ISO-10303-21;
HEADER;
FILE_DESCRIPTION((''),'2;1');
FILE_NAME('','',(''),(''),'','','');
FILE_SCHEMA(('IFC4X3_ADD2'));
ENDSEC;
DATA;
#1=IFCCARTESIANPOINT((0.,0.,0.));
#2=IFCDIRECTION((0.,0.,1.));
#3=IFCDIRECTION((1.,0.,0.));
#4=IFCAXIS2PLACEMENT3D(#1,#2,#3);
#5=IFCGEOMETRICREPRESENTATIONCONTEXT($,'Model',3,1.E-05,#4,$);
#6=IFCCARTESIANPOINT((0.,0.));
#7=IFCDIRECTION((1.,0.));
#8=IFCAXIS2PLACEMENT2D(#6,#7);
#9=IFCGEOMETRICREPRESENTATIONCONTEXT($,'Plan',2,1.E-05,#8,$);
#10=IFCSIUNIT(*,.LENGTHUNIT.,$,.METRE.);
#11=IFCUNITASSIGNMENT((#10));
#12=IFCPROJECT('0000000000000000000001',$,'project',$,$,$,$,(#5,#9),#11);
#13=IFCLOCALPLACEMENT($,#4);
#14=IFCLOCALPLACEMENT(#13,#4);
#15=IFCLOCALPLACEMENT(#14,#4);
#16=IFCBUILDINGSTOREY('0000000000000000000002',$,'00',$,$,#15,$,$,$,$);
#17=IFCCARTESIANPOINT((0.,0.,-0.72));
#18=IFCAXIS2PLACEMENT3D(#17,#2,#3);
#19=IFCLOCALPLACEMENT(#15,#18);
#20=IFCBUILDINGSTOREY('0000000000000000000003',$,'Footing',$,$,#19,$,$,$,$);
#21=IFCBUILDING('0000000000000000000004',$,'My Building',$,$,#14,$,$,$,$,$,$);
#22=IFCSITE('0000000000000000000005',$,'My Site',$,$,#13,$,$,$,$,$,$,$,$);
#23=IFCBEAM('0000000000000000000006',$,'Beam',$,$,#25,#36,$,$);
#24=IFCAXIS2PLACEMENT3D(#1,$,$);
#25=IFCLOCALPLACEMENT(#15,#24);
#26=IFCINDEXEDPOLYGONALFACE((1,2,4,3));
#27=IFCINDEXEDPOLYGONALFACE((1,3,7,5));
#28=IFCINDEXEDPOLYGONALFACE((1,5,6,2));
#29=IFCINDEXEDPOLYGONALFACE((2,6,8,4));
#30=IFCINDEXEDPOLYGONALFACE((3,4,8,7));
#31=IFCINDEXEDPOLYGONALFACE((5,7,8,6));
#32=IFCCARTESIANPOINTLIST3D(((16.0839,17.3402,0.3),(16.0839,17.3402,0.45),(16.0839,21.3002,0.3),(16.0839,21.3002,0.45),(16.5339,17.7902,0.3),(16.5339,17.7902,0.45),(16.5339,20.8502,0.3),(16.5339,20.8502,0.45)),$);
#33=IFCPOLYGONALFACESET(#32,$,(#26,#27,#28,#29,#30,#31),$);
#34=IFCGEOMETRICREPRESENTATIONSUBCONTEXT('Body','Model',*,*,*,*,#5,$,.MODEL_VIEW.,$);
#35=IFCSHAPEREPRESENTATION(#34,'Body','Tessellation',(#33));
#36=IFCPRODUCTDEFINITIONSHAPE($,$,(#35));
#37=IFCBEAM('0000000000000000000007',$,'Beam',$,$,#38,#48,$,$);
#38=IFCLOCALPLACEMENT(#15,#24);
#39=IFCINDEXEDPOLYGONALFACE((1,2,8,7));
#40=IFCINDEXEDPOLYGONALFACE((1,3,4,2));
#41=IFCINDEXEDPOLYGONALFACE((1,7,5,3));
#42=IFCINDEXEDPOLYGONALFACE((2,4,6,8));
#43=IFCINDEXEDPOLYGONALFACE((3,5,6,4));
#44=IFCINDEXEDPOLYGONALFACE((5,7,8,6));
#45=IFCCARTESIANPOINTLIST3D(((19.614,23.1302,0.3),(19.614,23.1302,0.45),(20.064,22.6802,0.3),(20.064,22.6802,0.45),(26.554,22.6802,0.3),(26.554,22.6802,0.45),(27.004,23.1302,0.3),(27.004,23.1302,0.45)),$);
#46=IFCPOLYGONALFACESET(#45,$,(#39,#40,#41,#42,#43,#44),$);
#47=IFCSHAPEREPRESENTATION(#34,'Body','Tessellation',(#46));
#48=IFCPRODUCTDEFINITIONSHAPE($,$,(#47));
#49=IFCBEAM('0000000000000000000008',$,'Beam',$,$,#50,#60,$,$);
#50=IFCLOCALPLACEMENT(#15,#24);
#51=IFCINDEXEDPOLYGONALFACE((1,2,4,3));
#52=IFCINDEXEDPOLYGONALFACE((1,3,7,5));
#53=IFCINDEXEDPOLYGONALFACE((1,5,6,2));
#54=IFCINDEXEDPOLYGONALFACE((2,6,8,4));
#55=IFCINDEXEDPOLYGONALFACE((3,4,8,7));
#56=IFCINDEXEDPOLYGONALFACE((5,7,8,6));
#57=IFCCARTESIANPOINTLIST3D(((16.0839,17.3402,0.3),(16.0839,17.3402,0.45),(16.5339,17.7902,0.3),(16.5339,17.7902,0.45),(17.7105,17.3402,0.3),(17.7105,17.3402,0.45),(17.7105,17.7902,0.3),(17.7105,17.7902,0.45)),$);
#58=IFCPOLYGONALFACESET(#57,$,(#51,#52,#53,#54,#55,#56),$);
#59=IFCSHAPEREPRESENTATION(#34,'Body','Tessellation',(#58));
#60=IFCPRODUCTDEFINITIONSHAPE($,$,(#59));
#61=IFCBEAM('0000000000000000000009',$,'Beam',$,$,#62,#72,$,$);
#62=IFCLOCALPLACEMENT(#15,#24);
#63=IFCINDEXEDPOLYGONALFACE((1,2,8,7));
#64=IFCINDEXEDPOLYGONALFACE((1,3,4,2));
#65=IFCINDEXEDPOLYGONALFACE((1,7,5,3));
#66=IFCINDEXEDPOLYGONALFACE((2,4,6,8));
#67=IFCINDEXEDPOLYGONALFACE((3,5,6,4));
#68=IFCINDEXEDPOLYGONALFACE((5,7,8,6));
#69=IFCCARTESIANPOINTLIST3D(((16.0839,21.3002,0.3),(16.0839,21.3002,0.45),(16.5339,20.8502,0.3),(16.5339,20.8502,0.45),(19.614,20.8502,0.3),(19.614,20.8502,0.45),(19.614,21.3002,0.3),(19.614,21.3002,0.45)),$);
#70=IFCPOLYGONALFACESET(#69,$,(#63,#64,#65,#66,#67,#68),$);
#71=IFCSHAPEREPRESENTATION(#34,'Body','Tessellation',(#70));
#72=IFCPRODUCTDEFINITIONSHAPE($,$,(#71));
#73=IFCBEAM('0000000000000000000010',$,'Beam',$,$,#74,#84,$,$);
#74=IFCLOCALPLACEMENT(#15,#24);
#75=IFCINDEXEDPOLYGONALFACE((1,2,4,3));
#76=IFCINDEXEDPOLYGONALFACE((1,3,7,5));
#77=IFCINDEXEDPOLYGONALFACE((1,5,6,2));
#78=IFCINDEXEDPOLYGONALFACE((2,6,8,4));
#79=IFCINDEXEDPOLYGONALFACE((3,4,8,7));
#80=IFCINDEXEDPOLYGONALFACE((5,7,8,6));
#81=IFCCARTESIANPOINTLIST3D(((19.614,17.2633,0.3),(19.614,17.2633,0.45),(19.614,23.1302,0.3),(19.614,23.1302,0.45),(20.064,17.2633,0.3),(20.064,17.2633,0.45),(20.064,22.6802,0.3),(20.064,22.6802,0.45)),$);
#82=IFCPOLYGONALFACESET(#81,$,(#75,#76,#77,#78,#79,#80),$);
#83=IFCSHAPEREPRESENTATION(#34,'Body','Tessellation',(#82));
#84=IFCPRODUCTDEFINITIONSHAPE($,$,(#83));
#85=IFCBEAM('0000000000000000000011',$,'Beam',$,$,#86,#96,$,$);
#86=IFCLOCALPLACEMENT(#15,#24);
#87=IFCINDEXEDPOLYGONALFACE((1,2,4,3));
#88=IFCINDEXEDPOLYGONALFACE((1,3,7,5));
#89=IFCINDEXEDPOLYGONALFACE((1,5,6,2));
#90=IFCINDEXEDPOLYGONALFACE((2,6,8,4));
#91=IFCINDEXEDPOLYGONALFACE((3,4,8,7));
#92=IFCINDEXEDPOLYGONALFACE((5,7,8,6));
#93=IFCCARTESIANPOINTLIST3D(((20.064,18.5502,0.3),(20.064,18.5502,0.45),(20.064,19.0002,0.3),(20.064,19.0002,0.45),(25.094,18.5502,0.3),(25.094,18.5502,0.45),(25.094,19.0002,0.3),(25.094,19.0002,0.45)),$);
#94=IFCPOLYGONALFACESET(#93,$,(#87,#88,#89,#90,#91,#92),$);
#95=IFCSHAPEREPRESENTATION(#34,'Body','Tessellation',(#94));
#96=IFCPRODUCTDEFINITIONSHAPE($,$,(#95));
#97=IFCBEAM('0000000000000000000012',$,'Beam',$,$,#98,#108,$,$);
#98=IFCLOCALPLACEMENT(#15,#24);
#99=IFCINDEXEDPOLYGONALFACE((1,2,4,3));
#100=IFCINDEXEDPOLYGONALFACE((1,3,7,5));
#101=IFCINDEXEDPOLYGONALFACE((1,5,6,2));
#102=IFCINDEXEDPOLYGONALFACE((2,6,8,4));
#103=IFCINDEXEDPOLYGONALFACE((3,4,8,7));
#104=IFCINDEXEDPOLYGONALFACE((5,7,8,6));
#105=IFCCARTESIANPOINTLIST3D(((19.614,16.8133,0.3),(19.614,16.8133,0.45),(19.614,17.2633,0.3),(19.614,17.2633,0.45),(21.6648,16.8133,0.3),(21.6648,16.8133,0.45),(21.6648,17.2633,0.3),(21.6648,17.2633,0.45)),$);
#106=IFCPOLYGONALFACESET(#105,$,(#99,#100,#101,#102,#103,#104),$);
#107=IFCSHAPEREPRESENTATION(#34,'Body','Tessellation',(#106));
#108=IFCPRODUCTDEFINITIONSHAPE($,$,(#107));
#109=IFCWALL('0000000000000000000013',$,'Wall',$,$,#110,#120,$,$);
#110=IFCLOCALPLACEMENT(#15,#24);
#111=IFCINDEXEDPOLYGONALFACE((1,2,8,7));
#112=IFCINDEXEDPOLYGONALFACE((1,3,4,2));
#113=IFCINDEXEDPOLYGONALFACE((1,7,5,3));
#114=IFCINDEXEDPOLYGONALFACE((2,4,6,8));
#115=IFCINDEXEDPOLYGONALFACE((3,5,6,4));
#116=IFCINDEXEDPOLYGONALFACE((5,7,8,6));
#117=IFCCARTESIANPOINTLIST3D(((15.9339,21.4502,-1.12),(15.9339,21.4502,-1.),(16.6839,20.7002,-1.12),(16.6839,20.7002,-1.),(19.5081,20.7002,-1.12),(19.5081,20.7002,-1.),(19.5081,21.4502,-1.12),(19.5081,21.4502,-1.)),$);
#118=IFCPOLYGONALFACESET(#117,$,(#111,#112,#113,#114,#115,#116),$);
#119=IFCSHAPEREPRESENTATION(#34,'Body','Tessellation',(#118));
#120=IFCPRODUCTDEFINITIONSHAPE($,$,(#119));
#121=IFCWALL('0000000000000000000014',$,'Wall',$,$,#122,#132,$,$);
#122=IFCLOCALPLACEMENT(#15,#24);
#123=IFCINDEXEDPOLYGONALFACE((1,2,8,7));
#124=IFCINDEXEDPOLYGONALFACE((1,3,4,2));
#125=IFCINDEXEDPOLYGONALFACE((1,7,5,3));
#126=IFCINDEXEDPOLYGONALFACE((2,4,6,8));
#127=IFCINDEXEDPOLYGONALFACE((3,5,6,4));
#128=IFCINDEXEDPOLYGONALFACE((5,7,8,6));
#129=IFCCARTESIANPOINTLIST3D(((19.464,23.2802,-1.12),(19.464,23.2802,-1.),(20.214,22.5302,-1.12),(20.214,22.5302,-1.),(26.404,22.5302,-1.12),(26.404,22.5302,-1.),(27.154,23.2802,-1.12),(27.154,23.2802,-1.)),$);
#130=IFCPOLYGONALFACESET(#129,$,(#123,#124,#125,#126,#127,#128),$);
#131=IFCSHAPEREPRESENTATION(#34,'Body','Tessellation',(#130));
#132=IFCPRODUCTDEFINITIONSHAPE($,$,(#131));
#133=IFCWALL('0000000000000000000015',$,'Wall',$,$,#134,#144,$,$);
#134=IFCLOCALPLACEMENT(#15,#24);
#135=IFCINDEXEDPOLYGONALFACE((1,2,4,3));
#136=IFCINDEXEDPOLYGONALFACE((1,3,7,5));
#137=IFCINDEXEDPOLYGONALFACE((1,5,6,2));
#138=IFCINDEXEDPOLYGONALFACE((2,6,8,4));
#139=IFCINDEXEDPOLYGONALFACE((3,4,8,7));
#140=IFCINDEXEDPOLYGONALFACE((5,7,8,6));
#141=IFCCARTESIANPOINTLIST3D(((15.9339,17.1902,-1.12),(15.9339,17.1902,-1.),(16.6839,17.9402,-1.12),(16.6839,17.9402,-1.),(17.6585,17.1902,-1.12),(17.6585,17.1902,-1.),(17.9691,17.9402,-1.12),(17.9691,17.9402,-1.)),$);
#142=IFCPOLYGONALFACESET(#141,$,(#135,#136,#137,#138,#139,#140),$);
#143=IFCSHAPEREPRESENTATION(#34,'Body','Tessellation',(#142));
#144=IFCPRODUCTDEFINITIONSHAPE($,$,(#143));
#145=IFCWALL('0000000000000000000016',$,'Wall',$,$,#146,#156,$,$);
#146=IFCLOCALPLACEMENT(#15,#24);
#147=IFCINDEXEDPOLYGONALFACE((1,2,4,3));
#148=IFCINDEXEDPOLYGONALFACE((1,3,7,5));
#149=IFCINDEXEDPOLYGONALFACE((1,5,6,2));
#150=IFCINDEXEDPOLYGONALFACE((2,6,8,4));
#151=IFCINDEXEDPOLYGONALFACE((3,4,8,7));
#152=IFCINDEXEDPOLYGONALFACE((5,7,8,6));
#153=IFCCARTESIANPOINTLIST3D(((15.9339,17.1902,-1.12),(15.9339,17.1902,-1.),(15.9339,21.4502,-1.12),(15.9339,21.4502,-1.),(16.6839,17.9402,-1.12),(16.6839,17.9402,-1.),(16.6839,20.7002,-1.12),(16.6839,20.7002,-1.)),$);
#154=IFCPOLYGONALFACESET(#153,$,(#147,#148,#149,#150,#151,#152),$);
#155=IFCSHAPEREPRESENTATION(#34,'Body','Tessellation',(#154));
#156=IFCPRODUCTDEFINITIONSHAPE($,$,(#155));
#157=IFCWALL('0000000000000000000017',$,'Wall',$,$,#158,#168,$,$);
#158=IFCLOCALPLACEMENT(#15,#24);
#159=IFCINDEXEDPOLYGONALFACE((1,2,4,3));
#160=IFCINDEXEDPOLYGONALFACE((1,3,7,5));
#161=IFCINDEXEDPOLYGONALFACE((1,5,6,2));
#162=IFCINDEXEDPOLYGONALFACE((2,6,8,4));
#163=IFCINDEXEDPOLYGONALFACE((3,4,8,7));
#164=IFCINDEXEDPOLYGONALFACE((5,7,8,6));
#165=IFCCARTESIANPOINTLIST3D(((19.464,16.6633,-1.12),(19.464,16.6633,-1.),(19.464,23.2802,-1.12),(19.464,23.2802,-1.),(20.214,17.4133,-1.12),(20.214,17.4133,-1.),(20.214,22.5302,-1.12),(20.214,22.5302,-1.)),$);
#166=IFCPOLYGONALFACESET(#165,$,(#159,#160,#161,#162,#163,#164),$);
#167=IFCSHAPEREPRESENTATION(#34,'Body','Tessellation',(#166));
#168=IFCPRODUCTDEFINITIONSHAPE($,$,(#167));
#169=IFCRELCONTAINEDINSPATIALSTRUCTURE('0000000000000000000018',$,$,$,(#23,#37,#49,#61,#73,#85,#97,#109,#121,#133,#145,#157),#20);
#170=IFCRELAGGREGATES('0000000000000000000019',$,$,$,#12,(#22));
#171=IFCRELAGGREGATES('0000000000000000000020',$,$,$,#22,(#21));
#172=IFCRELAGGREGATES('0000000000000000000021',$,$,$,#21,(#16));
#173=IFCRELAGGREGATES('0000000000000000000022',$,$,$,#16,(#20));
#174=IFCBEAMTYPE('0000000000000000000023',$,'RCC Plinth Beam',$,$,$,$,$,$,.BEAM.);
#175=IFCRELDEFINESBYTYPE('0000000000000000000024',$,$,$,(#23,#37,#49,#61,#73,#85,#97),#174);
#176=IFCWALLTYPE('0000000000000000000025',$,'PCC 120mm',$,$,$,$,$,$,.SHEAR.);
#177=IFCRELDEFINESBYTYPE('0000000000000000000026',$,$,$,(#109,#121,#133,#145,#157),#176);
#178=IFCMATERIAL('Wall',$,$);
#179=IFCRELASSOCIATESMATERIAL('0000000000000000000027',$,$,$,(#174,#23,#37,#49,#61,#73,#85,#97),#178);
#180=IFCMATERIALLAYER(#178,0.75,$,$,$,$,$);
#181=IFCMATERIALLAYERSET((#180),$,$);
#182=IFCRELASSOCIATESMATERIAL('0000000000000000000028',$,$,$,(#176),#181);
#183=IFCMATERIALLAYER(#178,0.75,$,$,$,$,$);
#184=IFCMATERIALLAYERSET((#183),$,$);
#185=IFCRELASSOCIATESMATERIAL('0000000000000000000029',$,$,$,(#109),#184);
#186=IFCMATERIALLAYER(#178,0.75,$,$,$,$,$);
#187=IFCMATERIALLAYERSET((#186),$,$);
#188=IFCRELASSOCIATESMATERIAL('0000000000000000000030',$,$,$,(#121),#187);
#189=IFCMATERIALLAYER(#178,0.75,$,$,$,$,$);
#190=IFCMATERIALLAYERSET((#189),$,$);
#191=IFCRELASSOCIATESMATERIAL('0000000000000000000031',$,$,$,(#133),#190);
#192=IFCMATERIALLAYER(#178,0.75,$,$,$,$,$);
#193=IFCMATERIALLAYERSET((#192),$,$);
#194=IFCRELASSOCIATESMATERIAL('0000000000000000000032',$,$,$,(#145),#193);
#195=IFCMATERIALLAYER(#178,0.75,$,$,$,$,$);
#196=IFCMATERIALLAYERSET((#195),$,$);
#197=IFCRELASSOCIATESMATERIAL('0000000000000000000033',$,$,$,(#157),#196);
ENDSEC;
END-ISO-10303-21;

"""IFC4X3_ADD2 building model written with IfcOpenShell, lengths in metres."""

from ifc_helpers import new_model, si_unit, frame, origin_with_axes, origin_2d_with_axis, place, context, subcontext, project, spatial, line, indexed_curve, rectangle, outline, extrude, clip, halfspace, material, layer, layer_set, layer_usage, material_profile, profile_set, profile_usage, type_object, element, save


model = new_model("IFC4X3_ADD2")

# Units and contexts
model_context = context("Model", 3, precision=1e-05, world=origin_with_axes())
plan_context = context("Plan", 2, precision=1e-05, world=origin_2d_with_axis())
body_context = subcontext(model_context, "Body", "Model", "MODEL_VIEW")
ifc_project = project(units=[si_unit("LENGTHUNIT", "METRE")], contexts=[model_context, plan_context])

# Site, building, storeys
site_placement = place(None, origin_with_axes())
site = spatial("IfcSite", under=ifc_project, at=site_placement, Name="My Site")
building_placement = place(site_placement, origin_with_axes())
building = spatial("IfcBuilding", under=site, at=building_placement, Name="My Building")
storey_1_placement = place(building_placement, origin_with_axes())
storey_1 = spatial("IfcBuildingStorey", under=building, at=storey_1_placement, Name="00")
storey_2_placement = place(storey_1_placement, frame((0.0, 0.0, -0.72), z_axis=(0.0, 0.0, 1.0), x_axis=(1.0, 0.0, 0.0)))
storey_2 = spatial("IfcBuildingStorey", under=storey_1, at=storey_2_placement, Name="Footing")

# Beams
ifc_material_1 = material(Name="Wall")
ifc_material_profile_1 = material_profile(ifc_material_1, rectangle(XDim=0.45, YDim=0.15))
ifc_profile_set_1 = profile_set([ifc_material_profile_1])
ifc_profile_usage_1 = profile_usage(ifc_profile_set_1, cardinal=5)
ifc_material_profile_2 = material_profile(ifc_material_1, rectangle(XDim=0.45, YDim=0.15))
ifc_profile_set_2 = profile_set([ifc_material_profile_2])
beam_type = type_object("IfcBeamType", Name="RCC Plinth Beam", PredefinedType="BEAM", material=ifc_profile_set_2)
beam_1_placement = place(storey_2_placement, frame((16.3089, 17.3402, 1.095), z_axis=(0.0, 1.0, 0.0), x_axis=(-1.0, 0.0, 0.0)))
element("IfcBeam", 1, at=beam_1_placement, inside=storey_2, type_object=beam_type, material=ifc_profile_usage_1, Name="Beam", context=body_context, shape_type="Clipping", body=[
    clip(clip(extrude(rectangle(XDim=0.45, YDim=0.15), origin_with_axes(), (0.0, 0.0, 1.0), 3.96), halfspace(frame((0.225, -0.375, 3.96), z_axis=(-0.707107, 0.0, 0.707107), x_axis=(0.0, 1.0, 0.0)), False)), halfspace(frame((0.225, -0.375, 0.0), z_axis=(-0.707107, 0.0, -0.707107), x_axis=(0.0, 1.0, 0.0)), False)),
])
ifc_material_profile_3 = material_profile(ifc_material_1, rectangle(XDim=0.45, YDim=0.15))
ifc_profile_set_3 = profile_set([ifc_material_profile_3])
ifc_profile_usage_2 = profile_usage(ifc_profile_set_3, cardinal=5)
beam_2_placement = place(storey_2_placement, frame((19.614, 22.9052, 1.095), z_axis=(1.0, 0.0, 0.0), x_axis=(0.0, 1.0, 0.0)))
element("IfcBeam", 2, at=beam_2_placement, inside=storey_2, type_object=beam_type, material=ifc_profile_usage_2, Name="Beam", context=body_context, shape_type="Clipping", body=[
    clip(clip(extrude(rectangle(XDim=0.45, YDim=0.15), origin_with_axes(), (0.0, 0.0, 1.0), 7.39), halfspace(frame((0.225, -0.375, 0.0), z_axis=(-0.707107, 0.0, -0.707107), x_axis=(0.0, 1.0, 0.0)), False)), halfspace(frame((0.225, -0.375, 7.39), z_axis=(-0.707107, 0.0, 0.707107), x_axis=(0.0, 1.0, 0.0)), False)),
])
ifc_material_profile_4 = material_profile(ifc_material_1, rectangle(XDim=0.45, YDim=0.15))
ifc_profile_set_4 = profile_set([ifc_material_profile_4])
ifc_profile_usage_3 = profile_usage(ifc_profile_set_4, cardinal=5)
beam_3_placement = place(storey_2_placement, frame((16.0839, 17.5652, 1.095), z_axis=(1.0, 0.0, 0.0), x_axis=(0.0, 1.0, 0.0)))
element("IfcBeam", 3, at=beam_3_placement, inside=storey_2, type_object=beam_type, material=ifc_profile_usage_3, Name="Beam", context=body_context, shape_type="Clipping", body=[
    clip(extrude(rectangle(XDim=0.45, YDim=0.15), origin_with_axes(), (0.0, 0.0, 1.0), 1.6266), halfspace(frame((-0.225, -0.375, 0.0), z_axis=(0.707107, 0.0, -0.707107), x_axis=(0.0, -1.0, 0.0)), False)),
])
ifc_material_profile_5 = material_profile(ifc_material_1, rectangle(XDim=0.45, YDim=0.15))
ifc_profile_set_5 = profile_set([ifc_material_profile_5])
ifc_profile_usage_4 = profile_usage(ifc_profile_set_5, cardinal=5)
beam_4_placement = place(storey_2_placement, frame((16.0839, 21.0752, 1.095), z_axis=(1.0, 0.0, 0.0), x_axis=(0.0, 1.0, 0.0)))
element("IfcBeam", 4, at=beam_4_placement, inside=storey_2, type_object=beam_type, material=ifc_profile_usage_4, Name="Beam", context=body_context, shape_type="Clipping", body=[
    clip(extrude(rectangle(XDim=0.45, YDim=0.15), origin_with_axes(), (0.0, 0.0, 1.0), 3.53), halfspace(frame((0.225, -0.375, 0.0), z_axis=(-0.707107, 0.0, -0.707107), x_axis=(0.0, 1.0, 0.0)), False)),
])
ifc_material_profile_6 = material_profile(ifc_material_1, rectangle(XDim=0.45, YDim=0.15))
ifc_profile_set_6 = profile_set([ifc_material_profile_6])
ifc_profile_usage_5 = profile_usage(ifc_profile_set_6, cardinal=5)
beam_5_placement = place(storey_2_placement, frame((19.839, 17.2633, 1.095), z_axis=(0.0, 1.0, 0.0), x_axis=(-1.0, 0.0, 0.0)))
element("IfcBeam", 5, at=beam_5_placement, inside=storey_2, type_object=beam_type, material=ifc_profile_usage_5, Name="Beam", context=body_context, shape_type="Clipping", body=[
    clip(extrude(rectangle(XDim=0.45, YDim=0.15), origin_with_axes(), (0.0, 0.0, 1.0), 5.8669), halfspace(frame((0.225, -0.375, 5.8669), z_axis=(-0.707107, 0.0, 0.707107), x_axis=(0.0, 1.0, 0.0)), False)),
])
ifc_material_profile_7 = material_profile(ifc_material_1, rectangle(XDim=0.45, YDim=0.15))
ifc_profile_set_7 = profile_set([ifc_material_profile_7])
ifc_profile_usage_6 = profile_usage(ifc_profile_set_7, cardinal=5)
beam_6_placement = place(storey_2_placement, frame((20.064, 18.7752, 1.095), z_axis=(1.0, 0.0, 0.0), x_axis=(0.0, 1.0, 0.0)))
element("IfcBeam", 6, at=beam_6_placement, inside=storey_2, type_object=beam_type, material=ifc_profile_usage_6, Name="Beam", context=body_context, shape_type="SweptSolid", body=[
    extrude(rectangle(XDim=0.45, YDim=0.15), origin_with_axes(), (0.0, 0.0, 1.0), 5.03),
])
ifc_profile_usage_7 = profile_usage(ifc_profile_set_7, cardinal=5)
beam_7_placement = place(storey_2_placement, frame((19.614, 17.0383, 1.095), z_axis=(1.0, 0.0, 0.0), x_axis=(0.0, 1.0, 0.0)))
element("IfcBeam", 7, at=beam_7_placement, inside=storey_2, type_object=beam_type, material=ifc_profile_usage_7, Name="Beam", context=body_context, shape_type="SweptSolid", body=[
    extrude(rectangle(XDim=0.45, YDim=0.15), origin_with_axes(), (0.0, 0.0, 1.0), 2.0508),
])

# Walls
ifc_layer_1 = layer(ifc_material_1, 0.75)
ifc_layer_set_1 = layer_set([ifc_layer_1])
ifc_layer_usage_1 = layer_usage(ifc_layer_set_1, "AXIS2", "POSITIVE", 0.0)
ifc_layer_2 = layer(ifc_material_1, 0.75)
ifc_layer_set_2 = layer_set([ifc_layer_2])
wall_type_1 = type_object("IfcWallType", Name="PCC 120mm", PredefinedType="SHEAR", material=ifc_layer_set_2)
wall_1_placement = place(storey_2_placement, frame((16.6839, 20.7002, -0.4), z_axis=(0.0, 0.0, 1.0), x_axis=(1.0, 0.0, 0.0)))
element("IfcWall", 8, at=wall_1_placement, inside=storey_2, type_object=wall_type_1, material=ifc_layer_usage_1, Name="Wall", context=body_context, shape_type="SweptSolid", body=[
    extrude(outline(indexed_curve([(0.0, 0.0), (-0.75, 0.75), (2.8241, 0.75), (2.8241, 0.0)], segments=[line(1, 2, 3, 4, 1)])), origin_with_axes(), (0.0, 0.0, 1.0), 0.12),
])
ifc_layer_3 = layer(ifc_material_1, 0.75)
ifc_layer_set_3 = layer_set([ifc_layer_3])
ifc_layer_usage_2 = layer_usage(ifc_layer_set_3, "AXIS2", "POSITIVE", 0.0)
wall_2_placement = place(storey_2_placement, frame((20.214, 22.5302, -0.4), z_axis=(0.0, 0.0, 1.0), x_axis=(1.0, 0.0, 0.0)))
element("IfcWall", 9, at=wall_2_placement, inside=storey_2, type_object=wall_type_1, material=ifc_layer_usage_2, Name="Wall", context=body_context, shape_type="SweptSolid", body=[
    extrude(outline(indexed_curve([(0.0, 0.0), (-0.75, 0.75), (6.94, 0.75), (6.19, 0.0)], segments=[line(1, 2, 3, 4, 1)])), origin_with_axes(), (0.0, 0.0, 1.0), 0.12),
])
ifc_layer_4 = layer(ifc_material_1, 0.75)
ifc_layer_set_4 = layer_set([ifc_layer_4])
ifc_layer_usage_3 = layer_usage(ifc_layer_set_4, "AXIS2", "POSITIVE", 0.0)
wall_3_placement = place(storey_2_placement, frame((16.6839, 17.1902, -0.4), z_axis=(0.0, 0.0, 1.0), x_axis=(1.0, 0.0, 0.0)))
element("IfcWall", 10, at=wall_3_placement, inside=storey_2, type_object=wall_type_1, material=ifc_layer_usage_3, Name="Wall", context=body_context, shape_type="SweptSolid", body=[
    extrude(outline(indexed_curve([(-0.75, 0.0), (0.0, 0.75), (1.2852, 0.75), (0.9745, 0.0)], segments=[line(1, 2, 3, 4, 1)])), origin_with_axes(), (0.0, 0.0, 1.0), 0.12),
])
ifc_layer_5 = layer(ifc_material_1, 0.75)
ifc_layer_set_5 = layer_set([ifc_layer_5])
ifc_layer_usage_4 = layer_usage(ifc_layer_set_5, "AXIS2", "POSITIVE", 0.0)
wall_4_placement = place(storey_2_placement, frame((16.6839, 17.1902, -0.4), z_axis=(0.0, 0.0, 1.0), x_axis=(0.0, 1.0, 0.0)))
element("IfcWall", 11, at=wall_4_placement, inside=storey_2, type_object=wall_type_1, material=ifc_layer_usage_4, Name="Wall", context=body_context, shape_type="SweptSolid", body=[
    extrude(outline(indexed_curve([(0.75, 0.0), (0.0, 0.75), (4.26, 0.75), (3.51, 0.0)], segments=[line(1, 2, 3, 4, 1)])), origin_with_axes(), (0.0, 0.0, 1.0), 0.12),
])
ifc_layer_6 = layer(ifc_material_1, 0.75)
ifc_layer_set_6 = layer_set([ifc_layer_6])
ifc_layer_usage_5 = layer_usage(ifc_layer_set_6, "AXIS2", "POSITIVE", 0.0)
wall_5_placement = place(storey_2_placement, frame((20.214, 16.6633, -0.4), z_axis=(0.0, 0.0, 1.0), x_axis=(0.0, 1.0, 0.0)))
element("IfcWall", 12, at=wall_5_placement, inside=storey_2, type_object=wall_type_1, material=ifc_layer_usage_5, Name="Wall", context=body_context, shape_type="SweptSolid", body=[
    extrude(outline(indexed_curve([(0.75, 0.0), (0.0, 0.75), (6.6169, 0.75), (5.8669, 0.0)], segments=[line(1, 2, 3, 4, 1)])), origin_with_axes(), (0.0, 0.0, 1.0), 0.12),
])

save(model, "model.ifc")
